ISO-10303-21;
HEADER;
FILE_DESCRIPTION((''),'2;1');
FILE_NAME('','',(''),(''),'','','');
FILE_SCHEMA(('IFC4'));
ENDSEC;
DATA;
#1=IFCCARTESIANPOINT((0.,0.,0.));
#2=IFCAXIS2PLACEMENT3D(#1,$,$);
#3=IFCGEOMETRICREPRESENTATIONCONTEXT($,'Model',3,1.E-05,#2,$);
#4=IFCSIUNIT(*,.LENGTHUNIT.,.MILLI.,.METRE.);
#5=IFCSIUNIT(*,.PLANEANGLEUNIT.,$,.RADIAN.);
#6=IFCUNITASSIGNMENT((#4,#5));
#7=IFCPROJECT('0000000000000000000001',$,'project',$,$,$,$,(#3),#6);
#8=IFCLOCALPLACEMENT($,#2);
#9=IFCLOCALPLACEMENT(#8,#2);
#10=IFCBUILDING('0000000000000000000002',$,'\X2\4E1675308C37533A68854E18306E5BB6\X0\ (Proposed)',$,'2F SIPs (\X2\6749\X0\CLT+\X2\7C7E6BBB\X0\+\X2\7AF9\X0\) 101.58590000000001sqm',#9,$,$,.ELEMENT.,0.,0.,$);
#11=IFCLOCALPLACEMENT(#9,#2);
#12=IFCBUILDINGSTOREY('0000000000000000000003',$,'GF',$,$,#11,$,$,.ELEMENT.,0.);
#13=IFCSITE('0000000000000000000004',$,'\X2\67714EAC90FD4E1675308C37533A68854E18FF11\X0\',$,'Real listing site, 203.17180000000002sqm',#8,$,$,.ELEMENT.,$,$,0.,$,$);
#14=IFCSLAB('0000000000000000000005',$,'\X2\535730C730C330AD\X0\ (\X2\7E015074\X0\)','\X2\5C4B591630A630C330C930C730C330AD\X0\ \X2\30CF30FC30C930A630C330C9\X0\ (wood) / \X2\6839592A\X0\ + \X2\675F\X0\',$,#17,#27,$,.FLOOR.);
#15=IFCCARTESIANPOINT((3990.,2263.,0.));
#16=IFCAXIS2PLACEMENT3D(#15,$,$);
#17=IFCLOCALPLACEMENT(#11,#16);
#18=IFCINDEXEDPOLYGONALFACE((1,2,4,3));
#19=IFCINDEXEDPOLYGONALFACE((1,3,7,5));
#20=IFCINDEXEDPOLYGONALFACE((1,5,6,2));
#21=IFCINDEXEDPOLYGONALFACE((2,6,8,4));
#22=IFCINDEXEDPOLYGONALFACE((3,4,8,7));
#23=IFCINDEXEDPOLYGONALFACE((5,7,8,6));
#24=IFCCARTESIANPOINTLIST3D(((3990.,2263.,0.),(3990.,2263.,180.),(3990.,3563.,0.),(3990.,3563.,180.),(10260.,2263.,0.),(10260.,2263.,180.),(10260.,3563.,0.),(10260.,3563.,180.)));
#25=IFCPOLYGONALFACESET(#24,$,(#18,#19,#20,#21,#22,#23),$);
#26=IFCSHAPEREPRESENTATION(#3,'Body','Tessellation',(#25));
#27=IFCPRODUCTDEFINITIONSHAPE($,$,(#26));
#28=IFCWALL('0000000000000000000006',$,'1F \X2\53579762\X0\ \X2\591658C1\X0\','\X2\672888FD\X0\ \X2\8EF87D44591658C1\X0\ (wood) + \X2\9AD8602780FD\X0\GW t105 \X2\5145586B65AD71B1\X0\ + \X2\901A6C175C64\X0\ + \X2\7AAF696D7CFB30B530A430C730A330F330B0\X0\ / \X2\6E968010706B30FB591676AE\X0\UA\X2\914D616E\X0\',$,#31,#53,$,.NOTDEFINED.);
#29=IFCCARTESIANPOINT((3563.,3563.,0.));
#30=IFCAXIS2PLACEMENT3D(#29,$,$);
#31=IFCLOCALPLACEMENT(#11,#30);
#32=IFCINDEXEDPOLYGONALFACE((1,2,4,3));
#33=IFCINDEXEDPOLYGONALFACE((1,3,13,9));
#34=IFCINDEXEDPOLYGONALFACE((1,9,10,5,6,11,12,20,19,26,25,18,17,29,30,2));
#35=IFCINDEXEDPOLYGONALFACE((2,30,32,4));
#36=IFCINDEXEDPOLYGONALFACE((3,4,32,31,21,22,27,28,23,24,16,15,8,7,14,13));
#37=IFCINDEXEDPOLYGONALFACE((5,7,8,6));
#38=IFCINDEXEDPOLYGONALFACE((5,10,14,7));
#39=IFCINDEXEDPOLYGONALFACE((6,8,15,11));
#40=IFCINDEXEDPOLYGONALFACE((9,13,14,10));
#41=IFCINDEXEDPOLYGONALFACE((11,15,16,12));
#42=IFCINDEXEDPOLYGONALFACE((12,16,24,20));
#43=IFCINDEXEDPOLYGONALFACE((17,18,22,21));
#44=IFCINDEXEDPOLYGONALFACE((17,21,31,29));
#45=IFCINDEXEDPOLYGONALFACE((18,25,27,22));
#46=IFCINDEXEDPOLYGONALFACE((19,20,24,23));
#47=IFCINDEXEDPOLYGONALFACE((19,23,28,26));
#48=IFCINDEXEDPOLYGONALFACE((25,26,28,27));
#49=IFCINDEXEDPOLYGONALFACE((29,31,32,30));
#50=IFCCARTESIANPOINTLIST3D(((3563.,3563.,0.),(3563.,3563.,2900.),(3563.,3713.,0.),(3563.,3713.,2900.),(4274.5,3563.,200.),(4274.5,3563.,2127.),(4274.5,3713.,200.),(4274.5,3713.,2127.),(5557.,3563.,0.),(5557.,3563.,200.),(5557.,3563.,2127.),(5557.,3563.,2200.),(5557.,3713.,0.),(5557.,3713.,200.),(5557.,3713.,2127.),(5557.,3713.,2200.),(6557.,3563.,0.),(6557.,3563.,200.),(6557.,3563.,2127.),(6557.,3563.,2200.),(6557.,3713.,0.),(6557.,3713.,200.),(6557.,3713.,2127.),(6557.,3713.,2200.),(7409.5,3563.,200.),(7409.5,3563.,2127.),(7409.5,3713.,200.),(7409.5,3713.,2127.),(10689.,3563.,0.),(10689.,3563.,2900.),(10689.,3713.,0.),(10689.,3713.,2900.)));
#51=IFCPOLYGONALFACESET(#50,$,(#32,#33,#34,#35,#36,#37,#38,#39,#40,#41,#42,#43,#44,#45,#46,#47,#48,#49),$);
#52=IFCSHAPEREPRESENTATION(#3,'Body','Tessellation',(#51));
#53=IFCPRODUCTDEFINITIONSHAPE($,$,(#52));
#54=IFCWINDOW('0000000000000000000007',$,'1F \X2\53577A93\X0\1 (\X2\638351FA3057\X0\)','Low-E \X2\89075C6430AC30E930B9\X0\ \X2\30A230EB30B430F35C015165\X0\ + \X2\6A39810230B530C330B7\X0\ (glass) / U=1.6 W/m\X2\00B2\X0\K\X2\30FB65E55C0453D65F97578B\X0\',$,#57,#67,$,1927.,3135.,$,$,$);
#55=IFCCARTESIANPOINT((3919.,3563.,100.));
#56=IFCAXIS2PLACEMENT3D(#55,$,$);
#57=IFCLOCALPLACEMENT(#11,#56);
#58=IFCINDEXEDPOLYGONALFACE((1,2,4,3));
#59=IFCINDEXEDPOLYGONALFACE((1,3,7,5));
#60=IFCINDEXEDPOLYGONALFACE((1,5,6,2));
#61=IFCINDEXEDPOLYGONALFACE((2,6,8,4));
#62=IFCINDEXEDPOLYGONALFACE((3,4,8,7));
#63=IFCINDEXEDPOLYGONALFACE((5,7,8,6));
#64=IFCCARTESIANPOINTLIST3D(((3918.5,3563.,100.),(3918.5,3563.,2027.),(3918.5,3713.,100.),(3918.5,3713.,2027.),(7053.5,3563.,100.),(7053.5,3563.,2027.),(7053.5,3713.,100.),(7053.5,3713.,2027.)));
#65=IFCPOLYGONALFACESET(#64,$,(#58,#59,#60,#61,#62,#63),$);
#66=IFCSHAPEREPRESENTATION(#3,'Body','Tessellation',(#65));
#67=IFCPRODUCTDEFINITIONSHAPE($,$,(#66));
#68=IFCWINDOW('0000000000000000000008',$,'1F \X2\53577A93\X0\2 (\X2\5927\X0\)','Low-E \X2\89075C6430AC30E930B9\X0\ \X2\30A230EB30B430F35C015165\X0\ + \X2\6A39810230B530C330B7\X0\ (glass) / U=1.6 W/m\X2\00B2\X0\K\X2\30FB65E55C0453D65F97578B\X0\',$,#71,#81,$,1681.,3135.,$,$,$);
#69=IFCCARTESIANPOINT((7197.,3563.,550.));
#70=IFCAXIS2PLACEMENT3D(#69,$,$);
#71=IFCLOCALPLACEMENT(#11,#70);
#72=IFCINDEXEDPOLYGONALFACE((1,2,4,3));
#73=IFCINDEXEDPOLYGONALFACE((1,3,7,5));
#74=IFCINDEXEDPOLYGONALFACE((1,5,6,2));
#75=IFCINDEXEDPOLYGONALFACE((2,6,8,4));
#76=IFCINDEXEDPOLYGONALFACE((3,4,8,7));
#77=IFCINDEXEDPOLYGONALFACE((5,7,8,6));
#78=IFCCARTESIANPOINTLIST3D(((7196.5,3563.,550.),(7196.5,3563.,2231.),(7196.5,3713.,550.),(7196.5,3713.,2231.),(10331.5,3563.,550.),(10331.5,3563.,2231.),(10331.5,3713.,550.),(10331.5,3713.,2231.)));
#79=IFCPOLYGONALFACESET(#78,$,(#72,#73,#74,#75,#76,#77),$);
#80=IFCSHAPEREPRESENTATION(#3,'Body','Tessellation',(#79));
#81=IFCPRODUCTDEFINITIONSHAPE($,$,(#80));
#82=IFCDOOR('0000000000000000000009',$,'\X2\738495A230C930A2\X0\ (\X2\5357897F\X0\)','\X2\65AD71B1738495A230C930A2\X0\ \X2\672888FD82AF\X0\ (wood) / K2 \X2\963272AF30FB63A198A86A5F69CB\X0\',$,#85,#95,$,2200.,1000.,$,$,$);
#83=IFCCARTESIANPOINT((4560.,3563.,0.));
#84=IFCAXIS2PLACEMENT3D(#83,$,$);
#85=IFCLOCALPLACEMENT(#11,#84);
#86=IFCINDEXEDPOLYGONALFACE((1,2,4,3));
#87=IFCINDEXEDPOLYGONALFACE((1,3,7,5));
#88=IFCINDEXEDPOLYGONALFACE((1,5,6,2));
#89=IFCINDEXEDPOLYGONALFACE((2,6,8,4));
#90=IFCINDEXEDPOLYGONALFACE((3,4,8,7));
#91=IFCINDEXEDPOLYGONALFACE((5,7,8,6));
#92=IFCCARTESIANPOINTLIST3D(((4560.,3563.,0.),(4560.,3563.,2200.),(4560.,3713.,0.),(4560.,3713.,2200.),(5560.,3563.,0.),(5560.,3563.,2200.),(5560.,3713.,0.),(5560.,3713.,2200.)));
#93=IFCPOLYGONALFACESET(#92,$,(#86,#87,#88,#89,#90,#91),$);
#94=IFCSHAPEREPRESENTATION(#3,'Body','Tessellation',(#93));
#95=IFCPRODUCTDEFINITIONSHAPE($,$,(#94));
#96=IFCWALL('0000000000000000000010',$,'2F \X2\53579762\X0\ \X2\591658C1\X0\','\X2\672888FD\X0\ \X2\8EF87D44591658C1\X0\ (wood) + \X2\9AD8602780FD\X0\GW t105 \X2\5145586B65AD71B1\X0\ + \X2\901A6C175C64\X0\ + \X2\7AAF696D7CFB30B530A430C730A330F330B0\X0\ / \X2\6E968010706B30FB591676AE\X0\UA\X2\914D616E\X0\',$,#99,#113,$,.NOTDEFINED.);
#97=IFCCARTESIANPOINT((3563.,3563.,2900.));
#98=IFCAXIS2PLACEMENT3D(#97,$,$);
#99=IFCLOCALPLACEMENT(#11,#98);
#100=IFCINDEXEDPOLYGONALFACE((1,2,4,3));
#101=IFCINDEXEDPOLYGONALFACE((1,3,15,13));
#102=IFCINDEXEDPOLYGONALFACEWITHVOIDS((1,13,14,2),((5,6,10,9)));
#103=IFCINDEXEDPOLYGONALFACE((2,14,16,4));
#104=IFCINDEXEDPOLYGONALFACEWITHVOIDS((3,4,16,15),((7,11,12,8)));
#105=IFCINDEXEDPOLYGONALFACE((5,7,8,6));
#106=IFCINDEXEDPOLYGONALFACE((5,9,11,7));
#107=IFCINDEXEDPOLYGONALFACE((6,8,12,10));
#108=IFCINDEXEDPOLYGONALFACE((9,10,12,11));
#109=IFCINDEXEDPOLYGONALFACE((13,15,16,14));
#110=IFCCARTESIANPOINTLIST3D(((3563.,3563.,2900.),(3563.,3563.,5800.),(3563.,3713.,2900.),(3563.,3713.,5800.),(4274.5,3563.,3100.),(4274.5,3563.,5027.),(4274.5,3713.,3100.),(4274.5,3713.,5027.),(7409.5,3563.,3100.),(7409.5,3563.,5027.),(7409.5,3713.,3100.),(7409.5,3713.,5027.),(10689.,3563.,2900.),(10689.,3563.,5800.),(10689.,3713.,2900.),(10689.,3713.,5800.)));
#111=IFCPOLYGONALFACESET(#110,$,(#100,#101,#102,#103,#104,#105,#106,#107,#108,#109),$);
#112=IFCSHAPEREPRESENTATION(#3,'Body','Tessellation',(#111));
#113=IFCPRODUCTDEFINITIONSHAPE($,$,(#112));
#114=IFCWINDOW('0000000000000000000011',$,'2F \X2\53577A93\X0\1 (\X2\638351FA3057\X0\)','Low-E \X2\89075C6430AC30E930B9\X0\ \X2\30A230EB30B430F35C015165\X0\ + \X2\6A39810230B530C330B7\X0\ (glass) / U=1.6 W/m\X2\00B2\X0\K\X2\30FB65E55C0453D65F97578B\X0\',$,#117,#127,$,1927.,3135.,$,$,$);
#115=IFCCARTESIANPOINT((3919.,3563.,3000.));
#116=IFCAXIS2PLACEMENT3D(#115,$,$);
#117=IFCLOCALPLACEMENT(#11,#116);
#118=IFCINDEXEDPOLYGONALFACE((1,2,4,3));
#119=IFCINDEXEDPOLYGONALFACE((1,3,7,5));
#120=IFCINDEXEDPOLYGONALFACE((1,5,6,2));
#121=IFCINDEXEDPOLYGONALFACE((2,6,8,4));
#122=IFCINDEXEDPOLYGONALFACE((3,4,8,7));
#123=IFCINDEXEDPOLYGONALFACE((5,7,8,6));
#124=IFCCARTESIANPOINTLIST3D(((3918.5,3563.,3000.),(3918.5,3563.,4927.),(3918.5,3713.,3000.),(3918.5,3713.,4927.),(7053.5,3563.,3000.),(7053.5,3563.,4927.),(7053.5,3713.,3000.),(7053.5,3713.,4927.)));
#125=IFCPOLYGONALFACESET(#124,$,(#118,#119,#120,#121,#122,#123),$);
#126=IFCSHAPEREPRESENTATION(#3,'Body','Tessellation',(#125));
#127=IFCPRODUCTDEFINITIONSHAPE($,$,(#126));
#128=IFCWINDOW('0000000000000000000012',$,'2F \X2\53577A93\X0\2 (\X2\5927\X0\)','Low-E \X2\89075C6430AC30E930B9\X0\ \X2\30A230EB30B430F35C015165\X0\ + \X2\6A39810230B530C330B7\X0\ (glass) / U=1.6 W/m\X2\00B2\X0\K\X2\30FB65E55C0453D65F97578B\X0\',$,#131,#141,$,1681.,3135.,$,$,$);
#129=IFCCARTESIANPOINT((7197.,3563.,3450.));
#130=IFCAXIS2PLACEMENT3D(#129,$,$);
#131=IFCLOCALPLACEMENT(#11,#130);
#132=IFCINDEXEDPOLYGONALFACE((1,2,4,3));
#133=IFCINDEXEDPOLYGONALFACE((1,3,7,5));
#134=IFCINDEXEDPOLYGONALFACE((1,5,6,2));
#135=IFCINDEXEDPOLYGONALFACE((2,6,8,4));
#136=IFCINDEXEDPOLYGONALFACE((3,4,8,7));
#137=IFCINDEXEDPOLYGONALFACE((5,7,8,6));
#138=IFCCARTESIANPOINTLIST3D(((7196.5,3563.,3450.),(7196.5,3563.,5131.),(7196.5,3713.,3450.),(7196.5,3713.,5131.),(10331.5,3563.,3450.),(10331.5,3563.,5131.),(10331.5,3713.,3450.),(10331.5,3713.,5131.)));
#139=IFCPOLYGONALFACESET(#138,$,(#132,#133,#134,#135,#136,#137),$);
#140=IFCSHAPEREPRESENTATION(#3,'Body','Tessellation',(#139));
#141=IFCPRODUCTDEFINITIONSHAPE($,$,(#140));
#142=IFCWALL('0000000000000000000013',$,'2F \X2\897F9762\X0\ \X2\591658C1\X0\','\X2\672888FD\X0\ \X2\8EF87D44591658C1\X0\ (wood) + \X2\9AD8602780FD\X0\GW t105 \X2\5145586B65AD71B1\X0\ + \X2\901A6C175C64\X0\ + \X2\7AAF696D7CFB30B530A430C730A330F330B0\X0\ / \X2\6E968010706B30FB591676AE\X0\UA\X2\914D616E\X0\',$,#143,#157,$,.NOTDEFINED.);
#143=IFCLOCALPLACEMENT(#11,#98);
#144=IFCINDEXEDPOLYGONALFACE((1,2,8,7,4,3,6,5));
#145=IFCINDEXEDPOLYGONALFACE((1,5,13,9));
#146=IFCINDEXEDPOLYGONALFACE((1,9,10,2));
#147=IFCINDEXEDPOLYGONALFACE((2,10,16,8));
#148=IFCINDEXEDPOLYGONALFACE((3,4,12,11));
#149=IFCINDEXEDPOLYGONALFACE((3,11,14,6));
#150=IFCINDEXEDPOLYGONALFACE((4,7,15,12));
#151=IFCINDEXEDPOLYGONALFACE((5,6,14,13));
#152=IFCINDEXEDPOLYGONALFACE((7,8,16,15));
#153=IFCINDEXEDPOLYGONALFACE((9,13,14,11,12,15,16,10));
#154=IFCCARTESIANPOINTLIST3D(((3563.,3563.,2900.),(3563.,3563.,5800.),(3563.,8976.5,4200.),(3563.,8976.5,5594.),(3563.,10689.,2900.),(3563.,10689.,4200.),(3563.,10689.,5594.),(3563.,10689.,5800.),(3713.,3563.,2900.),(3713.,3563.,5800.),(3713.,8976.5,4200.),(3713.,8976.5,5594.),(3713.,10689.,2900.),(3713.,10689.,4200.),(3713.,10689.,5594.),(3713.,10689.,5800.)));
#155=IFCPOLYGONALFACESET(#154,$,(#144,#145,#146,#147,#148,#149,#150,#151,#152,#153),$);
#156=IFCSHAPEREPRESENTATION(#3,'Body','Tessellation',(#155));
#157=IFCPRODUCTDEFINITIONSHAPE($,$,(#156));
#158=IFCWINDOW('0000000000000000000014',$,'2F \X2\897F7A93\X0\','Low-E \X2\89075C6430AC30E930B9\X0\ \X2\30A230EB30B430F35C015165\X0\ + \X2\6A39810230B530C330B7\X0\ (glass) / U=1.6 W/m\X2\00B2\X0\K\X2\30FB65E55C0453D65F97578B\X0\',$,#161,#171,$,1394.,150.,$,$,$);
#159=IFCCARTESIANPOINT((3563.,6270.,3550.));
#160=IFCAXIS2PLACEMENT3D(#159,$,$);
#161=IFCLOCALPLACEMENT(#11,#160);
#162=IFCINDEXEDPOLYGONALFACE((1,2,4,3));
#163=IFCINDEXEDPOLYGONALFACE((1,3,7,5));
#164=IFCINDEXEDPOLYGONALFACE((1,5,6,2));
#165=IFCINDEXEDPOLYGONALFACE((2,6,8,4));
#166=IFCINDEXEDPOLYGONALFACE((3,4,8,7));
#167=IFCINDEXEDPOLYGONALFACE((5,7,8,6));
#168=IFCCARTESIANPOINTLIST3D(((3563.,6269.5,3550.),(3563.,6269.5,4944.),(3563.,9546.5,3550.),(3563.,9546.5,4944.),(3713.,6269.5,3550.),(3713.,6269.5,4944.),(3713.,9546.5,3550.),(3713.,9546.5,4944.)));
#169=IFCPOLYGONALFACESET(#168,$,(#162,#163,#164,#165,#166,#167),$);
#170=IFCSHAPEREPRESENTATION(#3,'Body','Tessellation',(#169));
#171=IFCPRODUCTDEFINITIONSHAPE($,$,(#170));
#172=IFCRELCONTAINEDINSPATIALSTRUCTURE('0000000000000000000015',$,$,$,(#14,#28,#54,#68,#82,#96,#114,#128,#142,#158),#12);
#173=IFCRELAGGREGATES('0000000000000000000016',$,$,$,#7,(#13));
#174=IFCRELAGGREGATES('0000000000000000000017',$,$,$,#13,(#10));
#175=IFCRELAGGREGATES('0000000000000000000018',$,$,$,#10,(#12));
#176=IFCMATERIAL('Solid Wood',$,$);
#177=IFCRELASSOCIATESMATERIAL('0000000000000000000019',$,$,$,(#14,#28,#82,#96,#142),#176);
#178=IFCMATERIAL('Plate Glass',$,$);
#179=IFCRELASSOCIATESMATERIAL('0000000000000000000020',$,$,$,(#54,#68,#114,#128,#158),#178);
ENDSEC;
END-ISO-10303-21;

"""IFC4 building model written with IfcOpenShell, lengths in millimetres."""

from ifc_helpers import new_model, si_unit, frame, frame_2d, origin, place, context, project, spatial, rectangle, extrude, material, element, fill, save


model = new_model("IFC4")

# Units and contexts
model_context = context("Model", 3, precision=1e-05, world=origin())
ifc_project = project(units=[si_unit("LENGTHUNIT", "METRE", prefix="MILLI"), si_unit("PLANEANGLEUNIT", "RADIAN")], contexts=[model_context])

# Site, building, storey
site_placement = place(None, origin())
site = spatial("IfcSite", under=ifc_project, at=site_placement, Name="東京都世田谷区梅丘１", ObjectType="Real listing site, 203.17180000000002sqm", CompositionType="ELEMENT", RefElevation=0.0)
building_placement = place(site_placement, origin())
building = spatial("IfcBuilding", under=site, at=building_placement, Name="世田谷区梅丘の家 (Proposed)", ObjectType="2F SIPs (杉CLT+籾殻+竹) 101.58590000000001sqm", CompositionType="ELEMENT", ElevationOfRefHeight=0.0, ElevationOfTerrain=0.0)
storey_placement = place(building_placement, origin())
storey = spatial("IfcBuildingStorey", under=building, at=storey_placement, Name="GF", CompositionType="ELEMENT", Elevation=0.0)

# Slab
ifc_material_1 = material(Name="Solid Wood")
slab_1_placement = place(storey_placement, frame((3990.0, 2263.0, 0.0)))
element("IfcSlab", 1, at=slab_1_placement, inside=storey, material=ifc_material_1, Name="南デッキ (縁側)", Description="屋外ウッドデッキ ハードウッド (wood) / 根太 + 束", PredefinedType="FLOOR", context=model_context, shape_type="SweptSolid", body=[
    extrude(rectangle(XDim=6270.0, YDim=1300.0, at=frame_2d((3135.0, 650.0))), frame((3990.0, 2263.0, 0.0)), (0.0, 0.0, 1.0), 180.0),
])

# Wall, openings, windows, door
wall_1_placement = place(storey_placement, frame((3563.0, 3563.0, 0.0)))
wall_1 = element("IfcWall", 2, at=wall_1_placement, inside=storey, material=ifc_material_1, Name="1F 南面 外壁", Description="木製 軸組外壁 (wood) + 高性能GW t105 充填断熱 + 通気層 + 窯業系サイディング / 準耐火・外皮UA配慮", PredefinedType="NOTDEFINED", context=model_context, shape_type="SweptSolid", body=[
    extrude(rectangle(XDim=7126.0, YDim=150.0, at=frame_2d((3563.0, 75.0))), frame((3563.0, 3563.0, 0.0)), (0.0, 0.0, 1.0), 2900.0),
])
opening_1_placement = place(storey_placement, frame((3919.0, 3563.0, 100.0)))
opening_1 = element("IfcOpeningElement", 3, at=opening_1_placement, cuts=wall_1, PredefinedType="NOTDEFINED", context=model_context, shape_type="SweptSolid", body=[
    extrude(rectangle(XDim=3135.0, YDim=150.0, at=frame_2d((1567.0, 75.0))), frame((3919.0, 3563.0, 100.0)), (0.0, 0.0, 1.0), 1927.0),
])
opening_2_placement = place(storey_placement, frame((7197.0, 3563.0, 550.0)))
opening_2 = element("IfcOpeningElement", 4, at=opening_2_placement, cuts=wall_1, PredefinedType="NOTDEFINED", context=model_context, shape_type="SweptSolid", body=[
    extrude(rectangle(XDim=3135.0, YDim=150.0, at=frame_2d((1567.0, 75.0))), frame((7197.0, 3563.0, 550.0)), (0.0, 0.0, 1.0), 1681.0),
])
opening_3_placement = place(storey_placement, frame((4560.0, 3563.0, 0.0)))
opening_3 = element("IfcOpeningElement", 5, at=opening_3_placement, cuts=wall_1, PredefinedType="NOTDEFINED", context=model_context, shape_type="SweptSolid", body=[
    extrude(rectangle(XDim=1000.0, YDim=150.0, at=frame_2d((500.0, 75.0))), frame((4560.0, 3563.0, 0.0)), (0.0, 0.0, 1.0), 2200.0),
])
ifc_material_2 = material(Name="Plate Glass")
window_1_placement = place(storey_placement, frame((3919.0, 3563.0, 100.0)))
window_1 = element("IfcWindow", 6, at=window_1_placement, inside=storey, material=ifc_material_2, Name="1F 南窓1 (掃出し)", Description="Low-E 複層ガラス アルゴン封入 + 樹脂サッシ (glass) / U=1.6 W/m²K・日射取得型", OverallHeight=1927.0, OverallWidth=3135.0, context=model_context, shape_type="SweptSolid", body=[
    extrude(rectangle(XDim=3135.0, YDim=150.0, at=frame_2d((1567.0, 75.0))), frame((3919.0, 3563.0, 100.0)), (0.0, 0.0, 1.0), 1927.0),
])
fill(opening_1, window_1)
window_2_placement = place(storey_placement, frame((7197.0, 3563.0, 550.0)))
window_2 = element("IfcWindow", 7, at=window_2_placement, inside=storey, material=ifc_material_2, Name="1F 南窓2 (大)", Description="Low-E 複層ガラス アルゴン封入 + 樹脂サッシ (glass) / U=1.6 W/m²K・日射取得型", OverallHeight=1681.0, OverallWidth=3135.0, context=model_context, shape_type="SweptSolid", body=[
    extrude(rectangle(XDim=3135.0, YDim=150.0, at=frame_2d((1567.0, 75.0))), frame((7197.0, 3563.0, 550.0)), (0.0, 0.0, 1.0), 1681.0),
])
fill(opening_2, window_2)
door_placement = place(storey_placement, frame((4560.0, 3563.0, 0.0)))
door = element("IfcDoor", 8, at=door_placement, inside=storey, material=ifc_material_1, Name="玄関ドア (南西)", Description="断熱玄関ドア 木製芯 (wood) / K2 防犯・採風機構", OverallHeight=2200.0, OverallWidth=1000.0, context=model_context, shape_type="SweptSolid", body=[
    extrude(rectangle(XDim=1000.0, YDim=150.0, at=frame_2d((500.0, 75.0))), frame((4560.0, 3563.0, 0.0)), (0.0, 0.0, 1.0), 2200.0),
])
fill(opening_3, door)

# Wall, openings, windows
wall_2_placement = place(storey_placement, frame((3563.0, 3563.0, 2900.0)))
wall_2 = element("IfcWall", 9, at=wall_2_placement, inside=storey, material=ifc_material_1, Name="2F 南面 外壁", Description="木製 軸組外壁 (wood) + 高性能GW t105 充填断熱 + 通気層 + 窯業系サイディング / 準耐火・外皮UA配慮", PredefinedType="NOTDEFINED", context=model_context, shape_type="SweptSolid", body=[
    extrude(rectangle(XDim=7126.0, YDim=150.0, at=frame_2d((3563.0, 75.0))), frame((3563.0, 3563.0, 2900.0)), (0.0, 0.0, 1.0), 2900.0),
])
opening_4_placement = place(storey_placement, frame((3919.0, 3563.0, 3000.0)))
opening_4 = element("IfcOpeningElement", 10, at=opening_4_placement, cuts=wall_2, PredefinedType="NOTDEFINED", context=model_context, shape_type="SweptSolid", body=[
    extrude(rectangle(XDim=3135.0, YDim=150.0, at=frame_2d((1567.0, 75.0))), frame((3919.0, 3563.0, 3000.0)), (0.0, 0.0, 1.0), 1927.0),
])
opening_5_placement = place(storey_placement, frame((7197.0, 3563.0, 3450.0)))
opening_5 = element("IfcOpeningElement", 11, at=opening_5_placement, cuts=wall_2, PredefinedType="NOTDEFINED", context=model_context, shape_type="SweptSolid", body=[
    extrude(rectangle(XDim=3135.0, YDim=150.0, at=frame_2d((1567.0, 75.0))), frame((7197.0, 3563.0, 3450.0)), (0.0, 0.0, 1.0), 1681.0),
])
window_3_placement = place(storey_placement, frame((3919.0, 3563.0, 3000.0)))
window_3 = element("IfcWindow", 12, at=window_3_placement, inside=storey, material=ifc_material_2, Name="2F 南窓1 (掃出し)", Description="Low-E 複層ガラス アルゴン封入 + 樹脂サッシ (glass) / U=1.6 W/m²K・日射取得型", OverallHeight=1927.0, OverallWidth=3135.0, context=model_context, shape_type="SweptSolid", body=[
    extrude(rectangle(XDim=3135.0, YDim=150.0, at=frame_2d((1567.0, 75.0))), frame((3919.0, 3563.0, 3000.0)), (0.0, 0.0, 1.0), 1927.0),
])
fill(opening_4, window_3)
window_4_placement = place(storey_placement, frame((7197.0, 3563.0, 3450.0)))
window_4 = element("IfcWindow", 13, at=window_4_placement, inside=storey, material=ifc_material_2, Name="2F 南窓2 (大)", Description="Low-E 複層ガラス アルゴン封入 + 樹脂サッシ (glass) / U=1.6 W/m²K・日射取得型", OverallHeight=1681.0, OverallWidth=3135.0, context=model_context, shape_type="SweptSolid", body=[
    extrude(rectangle(XDim=3135.0, YDim=150.0, at=frame_2d((1567.0, 75.0))), frame((7197.0, 3563.0, 3450.0)), (0.0, 0.0, 1.0), 1681.0),
])
fill(opening_5, window_4)

# Wall, opening, window
wall_3_placement = place(storey_placement, frame((3563.0, 3563.0, 2900.0)))
wall_3 = element("IfcWall", 14, at=wall_3_placement, inside=storey, material=ifc_material_1, Name="2F 西面 外壁", Description="木製 軸組外壁 (wood) + 高性能GW t105 充填断熱 + 通気層 + 窯業系サイディング / 準耐火・外皮UA配慮", PredefinedType="NOTDEFINED", context=model_context, shape_type="SweptSolid", body=[
    extrude(rectangle(XDim=150.0, YDim=7126.0, at=frame_2d((75.0, 3563.0))), frame((3563.0, 3563.0, 2900.0)), (0.0, 0.0, 1.0), 2900.0),
])
opening_6_placement = place(storey_placement, frame((3563.0, 6270.0, 3550.0)))
opening_6 = element("IfcOpeningElement", 15, at=opening_6_placement, cuts=wall_3, PredefinedType="NOTDEFINED", context=model_context, shape_type="SweptSolid", body=[
    extrude(rectangle(XDim=150.0, YDim=3277.0, at=frame_2d((75.0, 1638.0))), frame((3563.0, 6270.0, 3550.0)), (0.0, 0.0, 1.0), 1394.0),
])
window_5_placement = place(storey_placement, frame((3563.0, 6270.0, 3550.0)))
window_5 = element("IfcWindow", 16, at=window_5_placement, inside=storey, material=ifc_material_2, Name="2F 西窓", Description="Low-E 複層ガラス アルゴン封入 + 樹脂サッシ (glass) / U=1.6 W/m²K・日射取得型", OverallHeight=1394.0, OverallWidth=150.0, context=model_context, shape_type="SweptSolid", body=[
    extrude(rectangle(XDim=150.0, YDim=3277.0, at=frame_2d((75.0, 1638.0))), frame((3563.0, 6270.0, 3550.0)), (0.0, 0.0, 1.0), 1394.0),
])
fill(opening_6, window_5)

save(model, "model.ifc")
